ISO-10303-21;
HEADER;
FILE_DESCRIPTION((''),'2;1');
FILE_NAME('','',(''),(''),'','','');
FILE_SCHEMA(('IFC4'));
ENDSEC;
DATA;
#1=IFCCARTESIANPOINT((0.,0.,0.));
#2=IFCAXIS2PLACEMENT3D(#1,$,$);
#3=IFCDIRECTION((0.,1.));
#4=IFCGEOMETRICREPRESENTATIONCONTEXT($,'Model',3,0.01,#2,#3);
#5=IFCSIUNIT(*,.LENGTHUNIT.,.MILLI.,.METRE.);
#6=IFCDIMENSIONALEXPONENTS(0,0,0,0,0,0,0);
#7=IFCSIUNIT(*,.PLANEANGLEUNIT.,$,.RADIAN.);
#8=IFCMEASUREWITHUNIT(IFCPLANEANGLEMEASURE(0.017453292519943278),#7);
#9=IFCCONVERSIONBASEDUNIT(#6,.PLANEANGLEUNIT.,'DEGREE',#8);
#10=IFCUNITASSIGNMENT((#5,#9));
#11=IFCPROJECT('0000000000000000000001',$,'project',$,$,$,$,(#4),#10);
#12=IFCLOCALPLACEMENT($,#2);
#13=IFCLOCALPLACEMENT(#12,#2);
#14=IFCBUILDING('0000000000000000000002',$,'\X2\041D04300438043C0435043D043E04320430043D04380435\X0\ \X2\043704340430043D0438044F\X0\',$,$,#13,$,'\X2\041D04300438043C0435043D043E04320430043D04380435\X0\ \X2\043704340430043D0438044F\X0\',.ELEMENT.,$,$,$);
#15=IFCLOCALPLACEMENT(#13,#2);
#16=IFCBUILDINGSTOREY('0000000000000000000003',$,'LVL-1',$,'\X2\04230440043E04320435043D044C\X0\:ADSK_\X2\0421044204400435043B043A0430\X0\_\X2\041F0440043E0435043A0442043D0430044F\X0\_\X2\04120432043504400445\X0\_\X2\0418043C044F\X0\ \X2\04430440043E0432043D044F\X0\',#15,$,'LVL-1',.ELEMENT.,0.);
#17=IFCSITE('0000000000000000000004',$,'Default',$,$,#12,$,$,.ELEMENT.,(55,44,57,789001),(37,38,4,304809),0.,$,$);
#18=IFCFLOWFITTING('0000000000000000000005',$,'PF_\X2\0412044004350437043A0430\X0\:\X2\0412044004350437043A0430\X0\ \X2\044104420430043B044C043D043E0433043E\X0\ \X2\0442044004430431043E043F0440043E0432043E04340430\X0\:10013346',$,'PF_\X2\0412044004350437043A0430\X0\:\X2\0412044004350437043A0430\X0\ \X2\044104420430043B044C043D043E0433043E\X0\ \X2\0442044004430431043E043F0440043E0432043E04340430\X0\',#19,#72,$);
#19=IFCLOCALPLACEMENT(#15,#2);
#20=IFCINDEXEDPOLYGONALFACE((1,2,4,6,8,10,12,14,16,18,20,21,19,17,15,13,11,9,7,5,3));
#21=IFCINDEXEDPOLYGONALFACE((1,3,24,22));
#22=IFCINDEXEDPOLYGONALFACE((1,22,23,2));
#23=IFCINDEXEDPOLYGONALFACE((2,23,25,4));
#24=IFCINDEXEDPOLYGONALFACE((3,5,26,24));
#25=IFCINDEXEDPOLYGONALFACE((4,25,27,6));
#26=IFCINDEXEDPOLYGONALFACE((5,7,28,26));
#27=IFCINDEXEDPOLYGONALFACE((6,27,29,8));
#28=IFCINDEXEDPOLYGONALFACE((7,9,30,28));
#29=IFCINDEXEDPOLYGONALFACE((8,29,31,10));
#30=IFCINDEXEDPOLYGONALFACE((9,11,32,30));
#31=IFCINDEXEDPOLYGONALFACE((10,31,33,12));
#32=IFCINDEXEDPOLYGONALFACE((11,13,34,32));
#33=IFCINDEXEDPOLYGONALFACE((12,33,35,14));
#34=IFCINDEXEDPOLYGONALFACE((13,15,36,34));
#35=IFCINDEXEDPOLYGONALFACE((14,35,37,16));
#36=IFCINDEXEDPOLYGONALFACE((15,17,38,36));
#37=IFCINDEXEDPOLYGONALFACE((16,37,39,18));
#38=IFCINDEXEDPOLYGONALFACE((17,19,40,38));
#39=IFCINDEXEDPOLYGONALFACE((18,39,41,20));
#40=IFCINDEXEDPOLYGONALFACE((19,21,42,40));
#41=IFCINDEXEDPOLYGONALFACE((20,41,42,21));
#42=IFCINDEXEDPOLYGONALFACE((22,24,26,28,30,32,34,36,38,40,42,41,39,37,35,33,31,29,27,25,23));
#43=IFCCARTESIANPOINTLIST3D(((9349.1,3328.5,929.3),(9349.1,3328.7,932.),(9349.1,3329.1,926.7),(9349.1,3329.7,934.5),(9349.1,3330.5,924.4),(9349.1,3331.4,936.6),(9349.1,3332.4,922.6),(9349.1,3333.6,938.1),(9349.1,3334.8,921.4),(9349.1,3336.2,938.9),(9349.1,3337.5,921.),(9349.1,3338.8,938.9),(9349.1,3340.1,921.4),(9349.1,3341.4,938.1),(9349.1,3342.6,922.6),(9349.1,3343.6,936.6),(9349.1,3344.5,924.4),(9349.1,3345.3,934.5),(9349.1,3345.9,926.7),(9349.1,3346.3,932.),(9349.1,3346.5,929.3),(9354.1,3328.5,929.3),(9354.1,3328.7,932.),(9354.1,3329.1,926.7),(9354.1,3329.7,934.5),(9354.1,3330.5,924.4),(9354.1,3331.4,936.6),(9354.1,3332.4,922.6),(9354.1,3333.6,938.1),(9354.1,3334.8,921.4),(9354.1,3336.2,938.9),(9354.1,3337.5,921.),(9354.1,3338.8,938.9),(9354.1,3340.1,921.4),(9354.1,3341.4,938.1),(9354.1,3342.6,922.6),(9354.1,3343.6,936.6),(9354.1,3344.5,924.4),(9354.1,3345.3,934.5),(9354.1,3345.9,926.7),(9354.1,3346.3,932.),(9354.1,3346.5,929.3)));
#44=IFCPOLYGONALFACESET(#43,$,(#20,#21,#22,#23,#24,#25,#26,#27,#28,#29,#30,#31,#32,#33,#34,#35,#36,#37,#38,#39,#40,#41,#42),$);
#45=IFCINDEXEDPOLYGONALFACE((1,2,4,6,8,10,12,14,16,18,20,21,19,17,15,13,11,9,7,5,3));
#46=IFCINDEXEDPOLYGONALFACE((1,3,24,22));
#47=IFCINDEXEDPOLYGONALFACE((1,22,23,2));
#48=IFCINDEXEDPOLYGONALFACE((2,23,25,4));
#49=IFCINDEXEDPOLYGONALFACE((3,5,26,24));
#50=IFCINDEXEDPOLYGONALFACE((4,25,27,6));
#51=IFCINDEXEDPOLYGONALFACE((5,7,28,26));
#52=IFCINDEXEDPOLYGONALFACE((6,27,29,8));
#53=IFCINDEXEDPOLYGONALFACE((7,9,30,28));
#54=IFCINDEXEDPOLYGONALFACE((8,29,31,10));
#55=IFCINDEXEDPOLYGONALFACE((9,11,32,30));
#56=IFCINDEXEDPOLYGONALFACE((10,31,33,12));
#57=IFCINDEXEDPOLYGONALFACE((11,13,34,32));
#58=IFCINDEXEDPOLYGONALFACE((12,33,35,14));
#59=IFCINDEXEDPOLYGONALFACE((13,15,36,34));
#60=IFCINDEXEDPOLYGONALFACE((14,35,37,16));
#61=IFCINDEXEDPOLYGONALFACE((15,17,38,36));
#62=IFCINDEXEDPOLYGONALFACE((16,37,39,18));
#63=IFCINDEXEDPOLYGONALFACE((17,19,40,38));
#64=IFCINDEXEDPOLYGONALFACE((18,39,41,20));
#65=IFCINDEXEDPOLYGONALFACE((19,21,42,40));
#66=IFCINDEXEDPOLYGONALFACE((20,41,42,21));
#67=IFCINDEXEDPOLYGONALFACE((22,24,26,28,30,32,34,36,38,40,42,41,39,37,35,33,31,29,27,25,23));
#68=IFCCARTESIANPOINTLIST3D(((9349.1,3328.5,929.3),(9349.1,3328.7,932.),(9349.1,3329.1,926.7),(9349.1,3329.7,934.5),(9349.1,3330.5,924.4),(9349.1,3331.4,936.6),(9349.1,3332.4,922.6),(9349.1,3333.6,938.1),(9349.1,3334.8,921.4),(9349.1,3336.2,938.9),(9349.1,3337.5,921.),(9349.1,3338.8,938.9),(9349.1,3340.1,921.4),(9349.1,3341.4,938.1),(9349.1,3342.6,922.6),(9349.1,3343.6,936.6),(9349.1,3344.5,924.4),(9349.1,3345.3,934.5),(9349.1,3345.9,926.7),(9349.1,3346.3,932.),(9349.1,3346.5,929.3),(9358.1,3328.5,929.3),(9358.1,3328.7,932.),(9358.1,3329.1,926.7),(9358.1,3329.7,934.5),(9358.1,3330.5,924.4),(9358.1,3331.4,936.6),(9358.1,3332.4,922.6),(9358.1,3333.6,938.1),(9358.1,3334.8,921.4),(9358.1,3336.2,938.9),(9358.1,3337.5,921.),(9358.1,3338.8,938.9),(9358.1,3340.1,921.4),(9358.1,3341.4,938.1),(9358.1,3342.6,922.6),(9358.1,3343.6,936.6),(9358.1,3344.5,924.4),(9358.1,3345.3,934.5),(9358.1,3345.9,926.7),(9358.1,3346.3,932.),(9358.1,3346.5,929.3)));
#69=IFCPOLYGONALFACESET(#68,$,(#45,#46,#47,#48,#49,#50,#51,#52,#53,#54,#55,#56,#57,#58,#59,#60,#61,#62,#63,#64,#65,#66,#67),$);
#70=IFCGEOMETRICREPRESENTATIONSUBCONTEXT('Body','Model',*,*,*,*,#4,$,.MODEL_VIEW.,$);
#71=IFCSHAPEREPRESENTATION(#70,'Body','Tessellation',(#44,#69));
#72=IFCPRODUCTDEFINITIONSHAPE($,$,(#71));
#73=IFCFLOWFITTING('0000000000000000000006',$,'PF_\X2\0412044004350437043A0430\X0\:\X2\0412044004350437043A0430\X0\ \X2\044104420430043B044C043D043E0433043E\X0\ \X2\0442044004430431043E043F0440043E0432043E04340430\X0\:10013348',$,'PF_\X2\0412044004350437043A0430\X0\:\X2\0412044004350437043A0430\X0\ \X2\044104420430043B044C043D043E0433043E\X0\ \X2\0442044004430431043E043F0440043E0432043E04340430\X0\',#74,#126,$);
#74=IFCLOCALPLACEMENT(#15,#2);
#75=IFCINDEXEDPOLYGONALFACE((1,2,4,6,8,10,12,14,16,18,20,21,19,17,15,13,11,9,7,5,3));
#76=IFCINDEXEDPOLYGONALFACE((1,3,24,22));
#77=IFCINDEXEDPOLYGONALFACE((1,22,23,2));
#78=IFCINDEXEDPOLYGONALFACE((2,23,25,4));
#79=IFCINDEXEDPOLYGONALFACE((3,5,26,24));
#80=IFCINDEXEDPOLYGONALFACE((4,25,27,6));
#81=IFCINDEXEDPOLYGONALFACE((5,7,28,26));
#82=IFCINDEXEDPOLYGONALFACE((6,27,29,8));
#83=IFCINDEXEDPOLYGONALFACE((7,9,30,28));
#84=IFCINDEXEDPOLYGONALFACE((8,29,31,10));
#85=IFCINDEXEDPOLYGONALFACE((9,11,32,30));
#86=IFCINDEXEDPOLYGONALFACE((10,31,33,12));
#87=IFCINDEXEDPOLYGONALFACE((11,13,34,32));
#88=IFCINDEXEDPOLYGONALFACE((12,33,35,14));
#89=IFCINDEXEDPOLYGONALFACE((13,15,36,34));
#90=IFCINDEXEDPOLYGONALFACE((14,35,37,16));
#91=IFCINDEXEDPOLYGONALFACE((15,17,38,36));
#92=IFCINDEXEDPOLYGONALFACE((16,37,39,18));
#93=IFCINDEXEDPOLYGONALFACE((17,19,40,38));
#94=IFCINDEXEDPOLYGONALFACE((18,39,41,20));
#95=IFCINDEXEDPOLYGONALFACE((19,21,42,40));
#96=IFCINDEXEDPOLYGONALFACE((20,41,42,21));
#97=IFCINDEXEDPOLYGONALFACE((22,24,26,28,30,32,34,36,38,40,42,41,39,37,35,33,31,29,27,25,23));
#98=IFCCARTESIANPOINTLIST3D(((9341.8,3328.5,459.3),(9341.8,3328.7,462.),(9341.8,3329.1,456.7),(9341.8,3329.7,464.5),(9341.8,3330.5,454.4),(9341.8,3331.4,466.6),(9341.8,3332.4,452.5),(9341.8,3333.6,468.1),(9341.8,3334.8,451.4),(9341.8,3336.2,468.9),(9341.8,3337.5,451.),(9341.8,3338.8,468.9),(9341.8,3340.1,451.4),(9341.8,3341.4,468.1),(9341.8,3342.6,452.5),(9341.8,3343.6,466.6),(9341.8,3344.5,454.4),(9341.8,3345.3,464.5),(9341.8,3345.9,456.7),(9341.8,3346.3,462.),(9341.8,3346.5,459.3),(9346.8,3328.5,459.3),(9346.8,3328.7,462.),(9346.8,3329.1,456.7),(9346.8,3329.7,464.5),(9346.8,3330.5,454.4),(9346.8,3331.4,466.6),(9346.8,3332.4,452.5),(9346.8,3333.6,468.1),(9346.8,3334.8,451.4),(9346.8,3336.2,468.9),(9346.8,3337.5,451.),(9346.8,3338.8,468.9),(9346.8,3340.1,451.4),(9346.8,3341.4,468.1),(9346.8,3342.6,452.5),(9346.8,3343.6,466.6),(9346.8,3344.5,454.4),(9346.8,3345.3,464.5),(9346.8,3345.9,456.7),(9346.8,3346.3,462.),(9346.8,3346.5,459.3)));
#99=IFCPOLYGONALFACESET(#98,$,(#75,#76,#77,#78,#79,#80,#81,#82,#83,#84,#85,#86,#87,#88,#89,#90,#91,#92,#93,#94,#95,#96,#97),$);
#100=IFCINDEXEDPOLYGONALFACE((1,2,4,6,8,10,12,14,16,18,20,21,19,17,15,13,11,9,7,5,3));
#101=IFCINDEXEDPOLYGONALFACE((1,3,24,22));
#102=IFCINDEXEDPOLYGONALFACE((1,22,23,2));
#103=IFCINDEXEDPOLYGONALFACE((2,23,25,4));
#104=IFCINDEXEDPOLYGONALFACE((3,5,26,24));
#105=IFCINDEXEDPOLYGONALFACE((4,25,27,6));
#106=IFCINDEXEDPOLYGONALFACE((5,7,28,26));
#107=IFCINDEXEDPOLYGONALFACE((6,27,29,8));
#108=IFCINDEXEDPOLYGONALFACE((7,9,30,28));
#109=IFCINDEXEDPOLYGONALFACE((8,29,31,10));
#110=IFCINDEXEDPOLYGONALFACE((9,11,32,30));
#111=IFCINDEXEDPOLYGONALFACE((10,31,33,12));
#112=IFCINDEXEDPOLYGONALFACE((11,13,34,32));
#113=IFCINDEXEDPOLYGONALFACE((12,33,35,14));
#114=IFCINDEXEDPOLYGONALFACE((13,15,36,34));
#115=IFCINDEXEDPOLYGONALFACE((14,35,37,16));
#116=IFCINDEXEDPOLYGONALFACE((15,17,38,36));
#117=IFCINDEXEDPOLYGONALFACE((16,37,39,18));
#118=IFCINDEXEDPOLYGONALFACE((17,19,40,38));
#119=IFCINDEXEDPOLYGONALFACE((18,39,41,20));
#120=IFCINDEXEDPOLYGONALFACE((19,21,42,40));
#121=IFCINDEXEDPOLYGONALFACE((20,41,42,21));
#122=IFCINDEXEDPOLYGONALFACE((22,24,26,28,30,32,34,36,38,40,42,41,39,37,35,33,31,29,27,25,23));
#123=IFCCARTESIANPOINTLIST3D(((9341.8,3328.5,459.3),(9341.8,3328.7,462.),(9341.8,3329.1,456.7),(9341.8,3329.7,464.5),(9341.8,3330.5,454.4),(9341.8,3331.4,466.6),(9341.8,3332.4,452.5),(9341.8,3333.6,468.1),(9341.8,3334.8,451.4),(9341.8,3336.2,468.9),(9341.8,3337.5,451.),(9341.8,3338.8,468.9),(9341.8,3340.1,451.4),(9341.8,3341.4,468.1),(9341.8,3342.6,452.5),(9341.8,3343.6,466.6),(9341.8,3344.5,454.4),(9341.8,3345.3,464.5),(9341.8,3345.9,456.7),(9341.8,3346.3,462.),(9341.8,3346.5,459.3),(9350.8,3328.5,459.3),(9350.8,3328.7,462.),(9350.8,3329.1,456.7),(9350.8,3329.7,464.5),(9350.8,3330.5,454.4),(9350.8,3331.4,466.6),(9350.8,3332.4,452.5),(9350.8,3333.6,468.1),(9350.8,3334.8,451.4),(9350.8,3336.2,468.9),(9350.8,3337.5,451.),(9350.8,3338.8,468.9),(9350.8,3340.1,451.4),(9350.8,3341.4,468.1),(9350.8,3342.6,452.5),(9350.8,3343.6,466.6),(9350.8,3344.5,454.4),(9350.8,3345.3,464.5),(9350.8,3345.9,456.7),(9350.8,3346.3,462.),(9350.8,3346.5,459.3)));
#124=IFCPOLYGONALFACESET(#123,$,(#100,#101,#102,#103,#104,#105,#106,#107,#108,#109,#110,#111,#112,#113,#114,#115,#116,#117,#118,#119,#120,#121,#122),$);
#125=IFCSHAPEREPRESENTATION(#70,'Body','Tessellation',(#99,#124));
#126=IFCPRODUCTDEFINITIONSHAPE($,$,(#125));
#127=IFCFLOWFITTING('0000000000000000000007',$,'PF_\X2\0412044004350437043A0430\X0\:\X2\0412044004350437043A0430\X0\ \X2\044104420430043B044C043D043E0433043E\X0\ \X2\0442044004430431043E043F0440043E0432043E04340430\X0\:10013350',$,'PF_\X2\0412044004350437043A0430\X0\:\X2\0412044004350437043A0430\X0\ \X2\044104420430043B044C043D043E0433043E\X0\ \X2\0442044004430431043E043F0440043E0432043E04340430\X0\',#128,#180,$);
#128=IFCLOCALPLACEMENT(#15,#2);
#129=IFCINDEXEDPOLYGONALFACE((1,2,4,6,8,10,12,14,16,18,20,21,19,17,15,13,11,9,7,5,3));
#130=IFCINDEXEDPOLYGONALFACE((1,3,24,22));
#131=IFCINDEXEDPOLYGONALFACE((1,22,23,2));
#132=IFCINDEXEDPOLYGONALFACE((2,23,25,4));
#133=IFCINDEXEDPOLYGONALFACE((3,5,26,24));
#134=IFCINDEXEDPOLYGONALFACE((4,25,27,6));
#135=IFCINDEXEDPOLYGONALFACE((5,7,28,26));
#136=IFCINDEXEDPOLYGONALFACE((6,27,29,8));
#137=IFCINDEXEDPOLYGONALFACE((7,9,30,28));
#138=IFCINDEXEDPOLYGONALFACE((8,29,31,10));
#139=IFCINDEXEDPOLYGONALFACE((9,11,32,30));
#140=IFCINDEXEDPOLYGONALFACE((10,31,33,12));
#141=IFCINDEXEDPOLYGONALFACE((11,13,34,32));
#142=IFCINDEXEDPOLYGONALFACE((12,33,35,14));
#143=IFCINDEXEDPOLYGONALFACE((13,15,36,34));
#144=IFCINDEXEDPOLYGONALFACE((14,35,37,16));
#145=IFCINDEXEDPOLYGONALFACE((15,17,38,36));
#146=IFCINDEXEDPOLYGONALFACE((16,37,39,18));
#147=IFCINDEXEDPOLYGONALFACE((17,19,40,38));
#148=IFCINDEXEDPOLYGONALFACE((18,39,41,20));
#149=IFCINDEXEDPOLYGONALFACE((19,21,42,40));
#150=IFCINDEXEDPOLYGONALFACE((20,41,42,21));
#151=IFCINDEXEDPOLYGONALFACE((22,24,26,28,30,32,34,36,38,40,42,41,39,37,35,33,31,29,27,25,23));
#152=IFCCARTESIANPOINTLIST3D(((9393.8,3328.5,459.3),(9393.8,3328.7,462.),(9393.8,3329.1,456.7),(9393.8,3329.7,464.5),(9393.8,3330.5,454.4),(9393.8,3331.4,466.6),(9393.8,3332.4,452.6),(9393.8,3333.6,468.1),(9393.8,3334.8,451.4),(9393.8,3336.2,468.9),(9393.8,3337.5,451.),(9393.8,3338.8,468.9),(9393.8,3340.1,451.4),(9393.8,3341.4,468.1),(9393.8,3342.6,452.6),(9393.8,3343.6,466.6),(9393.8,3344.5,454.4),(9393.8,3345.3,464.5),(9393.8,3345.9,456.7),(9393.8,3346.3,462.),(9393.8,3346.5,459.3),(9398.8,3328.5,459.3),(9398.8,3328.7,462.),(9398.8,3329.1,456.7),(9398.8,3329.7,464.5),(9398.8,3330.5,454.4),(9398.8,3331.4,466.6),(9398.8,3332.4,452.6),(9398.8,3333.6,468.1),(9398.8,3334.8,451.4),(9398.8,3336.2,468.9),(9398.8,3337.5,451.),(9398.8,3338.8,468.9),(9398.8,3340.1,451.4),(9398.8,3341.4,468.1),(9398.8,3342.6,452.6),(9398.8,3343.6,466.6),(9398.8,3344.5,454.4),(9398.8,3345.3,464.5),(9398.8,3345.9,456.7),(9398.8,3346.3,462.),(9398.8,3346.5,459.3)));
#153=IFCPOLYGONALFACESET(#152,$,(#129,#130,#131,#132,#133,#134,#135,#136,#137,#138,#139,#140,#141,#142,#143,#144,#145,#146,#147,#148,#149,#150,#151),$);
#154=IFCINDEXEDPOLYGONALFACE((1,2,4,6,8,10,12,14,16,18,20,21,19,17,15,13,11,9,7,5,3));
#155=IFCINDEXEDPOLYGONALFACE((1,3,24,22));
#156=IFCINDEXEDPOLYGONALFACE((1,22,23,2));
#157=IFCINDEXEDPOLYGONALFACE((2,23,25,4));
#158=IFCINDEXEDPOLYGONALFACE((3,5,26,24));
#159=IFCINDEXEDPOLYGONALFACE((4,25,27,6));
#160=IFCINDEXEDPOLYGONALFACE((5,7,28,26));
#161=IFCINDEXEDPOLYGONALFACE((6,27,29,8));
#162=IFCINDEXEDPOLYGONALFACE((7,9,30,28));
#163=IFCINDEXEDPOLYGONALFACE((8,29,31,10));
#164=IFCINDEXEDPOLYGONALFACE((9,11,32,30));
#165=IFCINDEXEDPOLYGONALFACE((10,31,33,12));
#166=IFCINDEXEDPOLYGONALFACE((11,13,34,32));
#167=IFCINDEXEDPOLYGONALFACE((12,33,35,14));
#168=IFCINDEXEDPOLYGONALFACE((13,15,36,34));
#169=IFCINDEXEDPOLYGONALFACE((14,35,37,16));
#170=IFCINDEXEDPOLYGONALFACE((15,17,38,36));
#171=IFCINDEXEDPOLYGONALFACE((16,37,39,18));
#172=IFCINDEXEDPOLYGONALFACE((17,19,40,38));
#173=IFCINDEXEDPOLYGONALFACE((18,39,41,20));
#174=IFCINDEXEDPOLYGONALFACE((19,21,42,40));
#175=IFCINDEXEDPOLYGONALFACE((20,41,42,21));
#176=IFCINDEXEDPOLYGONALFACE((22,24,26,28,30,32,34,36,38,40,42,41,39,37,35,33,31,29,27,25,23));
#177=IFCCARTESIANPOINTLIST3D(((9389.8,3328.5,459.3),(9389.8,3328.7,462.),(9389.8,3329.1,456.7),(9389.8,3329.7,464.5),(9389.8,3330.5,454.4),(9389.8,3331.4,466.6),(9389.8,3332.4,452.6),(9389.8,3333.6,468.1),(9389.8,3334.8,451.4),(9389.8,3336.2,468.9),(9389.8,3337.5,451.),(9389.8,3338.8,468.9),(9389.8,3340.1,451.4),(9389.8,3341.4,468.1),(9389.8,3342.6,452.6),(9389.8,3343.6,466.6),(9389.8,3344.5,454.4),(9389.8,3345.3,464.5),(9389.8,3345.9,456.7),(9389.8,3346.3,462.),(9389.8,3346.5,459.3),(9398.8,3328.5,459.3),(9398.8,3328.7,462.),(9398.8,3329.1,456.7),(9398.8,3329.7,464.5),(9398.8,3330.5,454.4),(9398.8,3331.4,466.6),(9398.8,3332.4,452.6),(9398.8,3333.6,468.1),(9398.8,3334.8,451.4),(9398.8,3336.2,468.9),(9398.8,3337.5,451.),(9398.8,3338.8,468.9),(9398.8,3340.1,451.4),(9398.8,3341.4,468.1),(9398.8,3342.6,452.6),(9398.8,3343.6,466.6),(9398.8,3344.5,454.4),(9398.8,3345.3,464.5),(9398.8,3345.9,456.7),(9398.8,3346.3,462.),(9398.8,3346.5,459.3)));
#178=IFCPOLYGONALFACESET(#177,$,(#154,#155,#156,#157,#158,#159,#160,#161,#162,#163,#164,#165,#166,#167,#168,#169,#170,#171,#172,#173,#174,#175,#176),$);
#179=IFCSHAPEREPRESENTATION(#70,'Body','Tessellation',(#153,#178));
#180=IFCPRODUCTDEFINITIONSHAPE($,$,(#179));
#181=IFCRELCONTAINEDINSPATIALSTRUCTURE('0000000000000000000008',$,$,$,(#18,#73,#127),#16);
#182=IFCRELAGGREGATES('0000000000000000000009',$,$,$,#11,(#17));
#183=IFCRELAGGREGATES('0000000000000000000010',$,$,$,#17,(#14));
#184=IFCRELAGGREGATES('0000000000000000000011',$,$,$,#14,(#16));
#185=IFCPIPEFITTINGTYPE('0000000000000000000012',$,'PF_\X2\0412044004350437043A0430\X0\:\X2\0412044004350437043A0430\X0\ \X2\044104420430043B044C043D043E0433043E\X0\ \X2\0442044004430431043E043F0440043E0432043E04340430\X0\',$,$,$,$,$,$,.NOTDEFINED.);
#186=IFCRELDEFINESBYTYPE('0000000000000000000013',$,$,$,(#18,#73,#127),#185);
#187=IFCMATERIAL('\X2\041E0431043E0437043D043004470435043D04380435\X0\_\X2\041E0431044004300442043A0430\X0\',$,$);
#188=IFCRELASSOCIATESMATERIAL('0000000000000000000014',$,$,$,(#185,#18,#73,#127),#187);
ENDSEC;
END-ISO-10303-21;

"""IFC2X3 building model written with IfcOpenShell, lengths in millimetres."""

from ifc_helpers import new_model, entity, si_unit, converted_unit, direction, frame, frame_2d, origin, place, context, subcontext, project, spatial, circle, extrude, source, transform, mapped, material, type_object, type_shapes, element, save


model = new_model("IFC2X3")

# Units and contexts
model_context = context("Model", 3, precision=0.01, world=origin(), true_north=direction((0.0, 1.0)))
body_context = subcontext(model_context, "Body", "Model", "MODEL_VIEW")
ifc_project = project(units=[si_unit("LENGTHUNIT", "METRE", prefix="MILLI"), converted_unit("PLANEANGLEUNIT", "DEGREE", entity("IfcPlaneAngleMeasure", 0.017453292519943278), si_unit("PLANEANGLEUNIT", "RADIAN"), dimensions=[0, 0, 0, 0, 0, 0, 0])], contexts=[model_context])

# Site, building, storey
site_placement = place(None, origin())
site = spatial("IfcSite", under=ifc_project, at=site_placement, Name="Default", CompositionType="ELEMENT", RefLatitude=(55, 44, 57, 789001), RefLongitude=(37, 38, 4, 304809), RefElevation=0.0)
building_placement = place(site_placement, origin())
building = spatial("IfcBuilding", under=site, at=building_placement, Name="Наименование здания", LongName="Наименование здания", CompositionType="ELEMENT")
storey_placement = place(building_placement, origin())
storey = spatial("IfcBuildingStorey", under=building, at=storey_placement, Name="LVL-1", ObjectType="Уровень:ADSK_Стрелка_Проектная_Вверх_Имя уровня", LongName="LVL-1", CompositionType="ELEMENT", Elevation=0.0)

# Flow fittings
ifc_material_1 = material(Name="Обозначение_Обратка")
pipe_fitting_type_1 = type_object("IfcPipeFittingType", Name="PF_Врезка:Врезка стального трубопровода", PredefinedType="NOTDEFINED", material=ifc_material_1)
shared_shape_1 = source(origin(), body_context, "Body", "SweptSolid", [
    extrude(circle(Radius=9.0, at=frame_2d((0.0, 0.0), x_axis=(1.0, 0.0))), frame((-5.0, 0.0, 0.0), z_axis=(1.0, 0.0, 0.0), x_axis=(0.0, -1.0, 0.0)), (0.0, 0.0, 1.0), 5.0),
    extrude(circle(Radius=9.0, at=frame_2d((0.0, 0.0), x_axis=(1.0, 0.0))), frame((-9.0, 0.0, 0.0), z_axis=(1.0, 0.0, 0.0), x_axis=(0.0, -1.0, 0.0)), (0.0, 0.0, 1.0), 9.0),
])
type_shapes(pipe_fitting_type_1, [shared_shape_1])
for number, where, z_axis, x_axis, name in (
    (1, (9349.1, 3337.5, 930.0), (0.0, 1.0, 0.0), (-1.0, 0.0, 0.0), "PF_Врезка:Врезка стального трубопровода:10013346"),
    (2, (9341.8, 3337.5, 460.0), (0.0, 1.0, 0.0), (-1.0, 0.0, 0.0), "PF_Врезка:Врезка стального трубопровода:10013348"),
    (3, (9398.8, 3337.5, 460.0), (0.0, -1.0, 0.0), (1.0, 0.0, 0.0), "PF_Врезка:Врезка стального трубопровода:10013350"),
):
    element("IfcFlowFitting", number, at=place(storey_placement, frame(where, z_axis=z_axis, x_axis=x_axis)), inside=storey, type_object=pipe_fitting_type_1, material=ifc_material_1, Name=name, ObjectType="PF_Врезка:Врезка стального трубопровода", context=body_context, shape_type="MappedRepresentation", body=[
        mapped(shared_shape_1, transform((0.0, 0.0, 0.0), scale=1.0)),
    ])

save(model, "model.ifc")
